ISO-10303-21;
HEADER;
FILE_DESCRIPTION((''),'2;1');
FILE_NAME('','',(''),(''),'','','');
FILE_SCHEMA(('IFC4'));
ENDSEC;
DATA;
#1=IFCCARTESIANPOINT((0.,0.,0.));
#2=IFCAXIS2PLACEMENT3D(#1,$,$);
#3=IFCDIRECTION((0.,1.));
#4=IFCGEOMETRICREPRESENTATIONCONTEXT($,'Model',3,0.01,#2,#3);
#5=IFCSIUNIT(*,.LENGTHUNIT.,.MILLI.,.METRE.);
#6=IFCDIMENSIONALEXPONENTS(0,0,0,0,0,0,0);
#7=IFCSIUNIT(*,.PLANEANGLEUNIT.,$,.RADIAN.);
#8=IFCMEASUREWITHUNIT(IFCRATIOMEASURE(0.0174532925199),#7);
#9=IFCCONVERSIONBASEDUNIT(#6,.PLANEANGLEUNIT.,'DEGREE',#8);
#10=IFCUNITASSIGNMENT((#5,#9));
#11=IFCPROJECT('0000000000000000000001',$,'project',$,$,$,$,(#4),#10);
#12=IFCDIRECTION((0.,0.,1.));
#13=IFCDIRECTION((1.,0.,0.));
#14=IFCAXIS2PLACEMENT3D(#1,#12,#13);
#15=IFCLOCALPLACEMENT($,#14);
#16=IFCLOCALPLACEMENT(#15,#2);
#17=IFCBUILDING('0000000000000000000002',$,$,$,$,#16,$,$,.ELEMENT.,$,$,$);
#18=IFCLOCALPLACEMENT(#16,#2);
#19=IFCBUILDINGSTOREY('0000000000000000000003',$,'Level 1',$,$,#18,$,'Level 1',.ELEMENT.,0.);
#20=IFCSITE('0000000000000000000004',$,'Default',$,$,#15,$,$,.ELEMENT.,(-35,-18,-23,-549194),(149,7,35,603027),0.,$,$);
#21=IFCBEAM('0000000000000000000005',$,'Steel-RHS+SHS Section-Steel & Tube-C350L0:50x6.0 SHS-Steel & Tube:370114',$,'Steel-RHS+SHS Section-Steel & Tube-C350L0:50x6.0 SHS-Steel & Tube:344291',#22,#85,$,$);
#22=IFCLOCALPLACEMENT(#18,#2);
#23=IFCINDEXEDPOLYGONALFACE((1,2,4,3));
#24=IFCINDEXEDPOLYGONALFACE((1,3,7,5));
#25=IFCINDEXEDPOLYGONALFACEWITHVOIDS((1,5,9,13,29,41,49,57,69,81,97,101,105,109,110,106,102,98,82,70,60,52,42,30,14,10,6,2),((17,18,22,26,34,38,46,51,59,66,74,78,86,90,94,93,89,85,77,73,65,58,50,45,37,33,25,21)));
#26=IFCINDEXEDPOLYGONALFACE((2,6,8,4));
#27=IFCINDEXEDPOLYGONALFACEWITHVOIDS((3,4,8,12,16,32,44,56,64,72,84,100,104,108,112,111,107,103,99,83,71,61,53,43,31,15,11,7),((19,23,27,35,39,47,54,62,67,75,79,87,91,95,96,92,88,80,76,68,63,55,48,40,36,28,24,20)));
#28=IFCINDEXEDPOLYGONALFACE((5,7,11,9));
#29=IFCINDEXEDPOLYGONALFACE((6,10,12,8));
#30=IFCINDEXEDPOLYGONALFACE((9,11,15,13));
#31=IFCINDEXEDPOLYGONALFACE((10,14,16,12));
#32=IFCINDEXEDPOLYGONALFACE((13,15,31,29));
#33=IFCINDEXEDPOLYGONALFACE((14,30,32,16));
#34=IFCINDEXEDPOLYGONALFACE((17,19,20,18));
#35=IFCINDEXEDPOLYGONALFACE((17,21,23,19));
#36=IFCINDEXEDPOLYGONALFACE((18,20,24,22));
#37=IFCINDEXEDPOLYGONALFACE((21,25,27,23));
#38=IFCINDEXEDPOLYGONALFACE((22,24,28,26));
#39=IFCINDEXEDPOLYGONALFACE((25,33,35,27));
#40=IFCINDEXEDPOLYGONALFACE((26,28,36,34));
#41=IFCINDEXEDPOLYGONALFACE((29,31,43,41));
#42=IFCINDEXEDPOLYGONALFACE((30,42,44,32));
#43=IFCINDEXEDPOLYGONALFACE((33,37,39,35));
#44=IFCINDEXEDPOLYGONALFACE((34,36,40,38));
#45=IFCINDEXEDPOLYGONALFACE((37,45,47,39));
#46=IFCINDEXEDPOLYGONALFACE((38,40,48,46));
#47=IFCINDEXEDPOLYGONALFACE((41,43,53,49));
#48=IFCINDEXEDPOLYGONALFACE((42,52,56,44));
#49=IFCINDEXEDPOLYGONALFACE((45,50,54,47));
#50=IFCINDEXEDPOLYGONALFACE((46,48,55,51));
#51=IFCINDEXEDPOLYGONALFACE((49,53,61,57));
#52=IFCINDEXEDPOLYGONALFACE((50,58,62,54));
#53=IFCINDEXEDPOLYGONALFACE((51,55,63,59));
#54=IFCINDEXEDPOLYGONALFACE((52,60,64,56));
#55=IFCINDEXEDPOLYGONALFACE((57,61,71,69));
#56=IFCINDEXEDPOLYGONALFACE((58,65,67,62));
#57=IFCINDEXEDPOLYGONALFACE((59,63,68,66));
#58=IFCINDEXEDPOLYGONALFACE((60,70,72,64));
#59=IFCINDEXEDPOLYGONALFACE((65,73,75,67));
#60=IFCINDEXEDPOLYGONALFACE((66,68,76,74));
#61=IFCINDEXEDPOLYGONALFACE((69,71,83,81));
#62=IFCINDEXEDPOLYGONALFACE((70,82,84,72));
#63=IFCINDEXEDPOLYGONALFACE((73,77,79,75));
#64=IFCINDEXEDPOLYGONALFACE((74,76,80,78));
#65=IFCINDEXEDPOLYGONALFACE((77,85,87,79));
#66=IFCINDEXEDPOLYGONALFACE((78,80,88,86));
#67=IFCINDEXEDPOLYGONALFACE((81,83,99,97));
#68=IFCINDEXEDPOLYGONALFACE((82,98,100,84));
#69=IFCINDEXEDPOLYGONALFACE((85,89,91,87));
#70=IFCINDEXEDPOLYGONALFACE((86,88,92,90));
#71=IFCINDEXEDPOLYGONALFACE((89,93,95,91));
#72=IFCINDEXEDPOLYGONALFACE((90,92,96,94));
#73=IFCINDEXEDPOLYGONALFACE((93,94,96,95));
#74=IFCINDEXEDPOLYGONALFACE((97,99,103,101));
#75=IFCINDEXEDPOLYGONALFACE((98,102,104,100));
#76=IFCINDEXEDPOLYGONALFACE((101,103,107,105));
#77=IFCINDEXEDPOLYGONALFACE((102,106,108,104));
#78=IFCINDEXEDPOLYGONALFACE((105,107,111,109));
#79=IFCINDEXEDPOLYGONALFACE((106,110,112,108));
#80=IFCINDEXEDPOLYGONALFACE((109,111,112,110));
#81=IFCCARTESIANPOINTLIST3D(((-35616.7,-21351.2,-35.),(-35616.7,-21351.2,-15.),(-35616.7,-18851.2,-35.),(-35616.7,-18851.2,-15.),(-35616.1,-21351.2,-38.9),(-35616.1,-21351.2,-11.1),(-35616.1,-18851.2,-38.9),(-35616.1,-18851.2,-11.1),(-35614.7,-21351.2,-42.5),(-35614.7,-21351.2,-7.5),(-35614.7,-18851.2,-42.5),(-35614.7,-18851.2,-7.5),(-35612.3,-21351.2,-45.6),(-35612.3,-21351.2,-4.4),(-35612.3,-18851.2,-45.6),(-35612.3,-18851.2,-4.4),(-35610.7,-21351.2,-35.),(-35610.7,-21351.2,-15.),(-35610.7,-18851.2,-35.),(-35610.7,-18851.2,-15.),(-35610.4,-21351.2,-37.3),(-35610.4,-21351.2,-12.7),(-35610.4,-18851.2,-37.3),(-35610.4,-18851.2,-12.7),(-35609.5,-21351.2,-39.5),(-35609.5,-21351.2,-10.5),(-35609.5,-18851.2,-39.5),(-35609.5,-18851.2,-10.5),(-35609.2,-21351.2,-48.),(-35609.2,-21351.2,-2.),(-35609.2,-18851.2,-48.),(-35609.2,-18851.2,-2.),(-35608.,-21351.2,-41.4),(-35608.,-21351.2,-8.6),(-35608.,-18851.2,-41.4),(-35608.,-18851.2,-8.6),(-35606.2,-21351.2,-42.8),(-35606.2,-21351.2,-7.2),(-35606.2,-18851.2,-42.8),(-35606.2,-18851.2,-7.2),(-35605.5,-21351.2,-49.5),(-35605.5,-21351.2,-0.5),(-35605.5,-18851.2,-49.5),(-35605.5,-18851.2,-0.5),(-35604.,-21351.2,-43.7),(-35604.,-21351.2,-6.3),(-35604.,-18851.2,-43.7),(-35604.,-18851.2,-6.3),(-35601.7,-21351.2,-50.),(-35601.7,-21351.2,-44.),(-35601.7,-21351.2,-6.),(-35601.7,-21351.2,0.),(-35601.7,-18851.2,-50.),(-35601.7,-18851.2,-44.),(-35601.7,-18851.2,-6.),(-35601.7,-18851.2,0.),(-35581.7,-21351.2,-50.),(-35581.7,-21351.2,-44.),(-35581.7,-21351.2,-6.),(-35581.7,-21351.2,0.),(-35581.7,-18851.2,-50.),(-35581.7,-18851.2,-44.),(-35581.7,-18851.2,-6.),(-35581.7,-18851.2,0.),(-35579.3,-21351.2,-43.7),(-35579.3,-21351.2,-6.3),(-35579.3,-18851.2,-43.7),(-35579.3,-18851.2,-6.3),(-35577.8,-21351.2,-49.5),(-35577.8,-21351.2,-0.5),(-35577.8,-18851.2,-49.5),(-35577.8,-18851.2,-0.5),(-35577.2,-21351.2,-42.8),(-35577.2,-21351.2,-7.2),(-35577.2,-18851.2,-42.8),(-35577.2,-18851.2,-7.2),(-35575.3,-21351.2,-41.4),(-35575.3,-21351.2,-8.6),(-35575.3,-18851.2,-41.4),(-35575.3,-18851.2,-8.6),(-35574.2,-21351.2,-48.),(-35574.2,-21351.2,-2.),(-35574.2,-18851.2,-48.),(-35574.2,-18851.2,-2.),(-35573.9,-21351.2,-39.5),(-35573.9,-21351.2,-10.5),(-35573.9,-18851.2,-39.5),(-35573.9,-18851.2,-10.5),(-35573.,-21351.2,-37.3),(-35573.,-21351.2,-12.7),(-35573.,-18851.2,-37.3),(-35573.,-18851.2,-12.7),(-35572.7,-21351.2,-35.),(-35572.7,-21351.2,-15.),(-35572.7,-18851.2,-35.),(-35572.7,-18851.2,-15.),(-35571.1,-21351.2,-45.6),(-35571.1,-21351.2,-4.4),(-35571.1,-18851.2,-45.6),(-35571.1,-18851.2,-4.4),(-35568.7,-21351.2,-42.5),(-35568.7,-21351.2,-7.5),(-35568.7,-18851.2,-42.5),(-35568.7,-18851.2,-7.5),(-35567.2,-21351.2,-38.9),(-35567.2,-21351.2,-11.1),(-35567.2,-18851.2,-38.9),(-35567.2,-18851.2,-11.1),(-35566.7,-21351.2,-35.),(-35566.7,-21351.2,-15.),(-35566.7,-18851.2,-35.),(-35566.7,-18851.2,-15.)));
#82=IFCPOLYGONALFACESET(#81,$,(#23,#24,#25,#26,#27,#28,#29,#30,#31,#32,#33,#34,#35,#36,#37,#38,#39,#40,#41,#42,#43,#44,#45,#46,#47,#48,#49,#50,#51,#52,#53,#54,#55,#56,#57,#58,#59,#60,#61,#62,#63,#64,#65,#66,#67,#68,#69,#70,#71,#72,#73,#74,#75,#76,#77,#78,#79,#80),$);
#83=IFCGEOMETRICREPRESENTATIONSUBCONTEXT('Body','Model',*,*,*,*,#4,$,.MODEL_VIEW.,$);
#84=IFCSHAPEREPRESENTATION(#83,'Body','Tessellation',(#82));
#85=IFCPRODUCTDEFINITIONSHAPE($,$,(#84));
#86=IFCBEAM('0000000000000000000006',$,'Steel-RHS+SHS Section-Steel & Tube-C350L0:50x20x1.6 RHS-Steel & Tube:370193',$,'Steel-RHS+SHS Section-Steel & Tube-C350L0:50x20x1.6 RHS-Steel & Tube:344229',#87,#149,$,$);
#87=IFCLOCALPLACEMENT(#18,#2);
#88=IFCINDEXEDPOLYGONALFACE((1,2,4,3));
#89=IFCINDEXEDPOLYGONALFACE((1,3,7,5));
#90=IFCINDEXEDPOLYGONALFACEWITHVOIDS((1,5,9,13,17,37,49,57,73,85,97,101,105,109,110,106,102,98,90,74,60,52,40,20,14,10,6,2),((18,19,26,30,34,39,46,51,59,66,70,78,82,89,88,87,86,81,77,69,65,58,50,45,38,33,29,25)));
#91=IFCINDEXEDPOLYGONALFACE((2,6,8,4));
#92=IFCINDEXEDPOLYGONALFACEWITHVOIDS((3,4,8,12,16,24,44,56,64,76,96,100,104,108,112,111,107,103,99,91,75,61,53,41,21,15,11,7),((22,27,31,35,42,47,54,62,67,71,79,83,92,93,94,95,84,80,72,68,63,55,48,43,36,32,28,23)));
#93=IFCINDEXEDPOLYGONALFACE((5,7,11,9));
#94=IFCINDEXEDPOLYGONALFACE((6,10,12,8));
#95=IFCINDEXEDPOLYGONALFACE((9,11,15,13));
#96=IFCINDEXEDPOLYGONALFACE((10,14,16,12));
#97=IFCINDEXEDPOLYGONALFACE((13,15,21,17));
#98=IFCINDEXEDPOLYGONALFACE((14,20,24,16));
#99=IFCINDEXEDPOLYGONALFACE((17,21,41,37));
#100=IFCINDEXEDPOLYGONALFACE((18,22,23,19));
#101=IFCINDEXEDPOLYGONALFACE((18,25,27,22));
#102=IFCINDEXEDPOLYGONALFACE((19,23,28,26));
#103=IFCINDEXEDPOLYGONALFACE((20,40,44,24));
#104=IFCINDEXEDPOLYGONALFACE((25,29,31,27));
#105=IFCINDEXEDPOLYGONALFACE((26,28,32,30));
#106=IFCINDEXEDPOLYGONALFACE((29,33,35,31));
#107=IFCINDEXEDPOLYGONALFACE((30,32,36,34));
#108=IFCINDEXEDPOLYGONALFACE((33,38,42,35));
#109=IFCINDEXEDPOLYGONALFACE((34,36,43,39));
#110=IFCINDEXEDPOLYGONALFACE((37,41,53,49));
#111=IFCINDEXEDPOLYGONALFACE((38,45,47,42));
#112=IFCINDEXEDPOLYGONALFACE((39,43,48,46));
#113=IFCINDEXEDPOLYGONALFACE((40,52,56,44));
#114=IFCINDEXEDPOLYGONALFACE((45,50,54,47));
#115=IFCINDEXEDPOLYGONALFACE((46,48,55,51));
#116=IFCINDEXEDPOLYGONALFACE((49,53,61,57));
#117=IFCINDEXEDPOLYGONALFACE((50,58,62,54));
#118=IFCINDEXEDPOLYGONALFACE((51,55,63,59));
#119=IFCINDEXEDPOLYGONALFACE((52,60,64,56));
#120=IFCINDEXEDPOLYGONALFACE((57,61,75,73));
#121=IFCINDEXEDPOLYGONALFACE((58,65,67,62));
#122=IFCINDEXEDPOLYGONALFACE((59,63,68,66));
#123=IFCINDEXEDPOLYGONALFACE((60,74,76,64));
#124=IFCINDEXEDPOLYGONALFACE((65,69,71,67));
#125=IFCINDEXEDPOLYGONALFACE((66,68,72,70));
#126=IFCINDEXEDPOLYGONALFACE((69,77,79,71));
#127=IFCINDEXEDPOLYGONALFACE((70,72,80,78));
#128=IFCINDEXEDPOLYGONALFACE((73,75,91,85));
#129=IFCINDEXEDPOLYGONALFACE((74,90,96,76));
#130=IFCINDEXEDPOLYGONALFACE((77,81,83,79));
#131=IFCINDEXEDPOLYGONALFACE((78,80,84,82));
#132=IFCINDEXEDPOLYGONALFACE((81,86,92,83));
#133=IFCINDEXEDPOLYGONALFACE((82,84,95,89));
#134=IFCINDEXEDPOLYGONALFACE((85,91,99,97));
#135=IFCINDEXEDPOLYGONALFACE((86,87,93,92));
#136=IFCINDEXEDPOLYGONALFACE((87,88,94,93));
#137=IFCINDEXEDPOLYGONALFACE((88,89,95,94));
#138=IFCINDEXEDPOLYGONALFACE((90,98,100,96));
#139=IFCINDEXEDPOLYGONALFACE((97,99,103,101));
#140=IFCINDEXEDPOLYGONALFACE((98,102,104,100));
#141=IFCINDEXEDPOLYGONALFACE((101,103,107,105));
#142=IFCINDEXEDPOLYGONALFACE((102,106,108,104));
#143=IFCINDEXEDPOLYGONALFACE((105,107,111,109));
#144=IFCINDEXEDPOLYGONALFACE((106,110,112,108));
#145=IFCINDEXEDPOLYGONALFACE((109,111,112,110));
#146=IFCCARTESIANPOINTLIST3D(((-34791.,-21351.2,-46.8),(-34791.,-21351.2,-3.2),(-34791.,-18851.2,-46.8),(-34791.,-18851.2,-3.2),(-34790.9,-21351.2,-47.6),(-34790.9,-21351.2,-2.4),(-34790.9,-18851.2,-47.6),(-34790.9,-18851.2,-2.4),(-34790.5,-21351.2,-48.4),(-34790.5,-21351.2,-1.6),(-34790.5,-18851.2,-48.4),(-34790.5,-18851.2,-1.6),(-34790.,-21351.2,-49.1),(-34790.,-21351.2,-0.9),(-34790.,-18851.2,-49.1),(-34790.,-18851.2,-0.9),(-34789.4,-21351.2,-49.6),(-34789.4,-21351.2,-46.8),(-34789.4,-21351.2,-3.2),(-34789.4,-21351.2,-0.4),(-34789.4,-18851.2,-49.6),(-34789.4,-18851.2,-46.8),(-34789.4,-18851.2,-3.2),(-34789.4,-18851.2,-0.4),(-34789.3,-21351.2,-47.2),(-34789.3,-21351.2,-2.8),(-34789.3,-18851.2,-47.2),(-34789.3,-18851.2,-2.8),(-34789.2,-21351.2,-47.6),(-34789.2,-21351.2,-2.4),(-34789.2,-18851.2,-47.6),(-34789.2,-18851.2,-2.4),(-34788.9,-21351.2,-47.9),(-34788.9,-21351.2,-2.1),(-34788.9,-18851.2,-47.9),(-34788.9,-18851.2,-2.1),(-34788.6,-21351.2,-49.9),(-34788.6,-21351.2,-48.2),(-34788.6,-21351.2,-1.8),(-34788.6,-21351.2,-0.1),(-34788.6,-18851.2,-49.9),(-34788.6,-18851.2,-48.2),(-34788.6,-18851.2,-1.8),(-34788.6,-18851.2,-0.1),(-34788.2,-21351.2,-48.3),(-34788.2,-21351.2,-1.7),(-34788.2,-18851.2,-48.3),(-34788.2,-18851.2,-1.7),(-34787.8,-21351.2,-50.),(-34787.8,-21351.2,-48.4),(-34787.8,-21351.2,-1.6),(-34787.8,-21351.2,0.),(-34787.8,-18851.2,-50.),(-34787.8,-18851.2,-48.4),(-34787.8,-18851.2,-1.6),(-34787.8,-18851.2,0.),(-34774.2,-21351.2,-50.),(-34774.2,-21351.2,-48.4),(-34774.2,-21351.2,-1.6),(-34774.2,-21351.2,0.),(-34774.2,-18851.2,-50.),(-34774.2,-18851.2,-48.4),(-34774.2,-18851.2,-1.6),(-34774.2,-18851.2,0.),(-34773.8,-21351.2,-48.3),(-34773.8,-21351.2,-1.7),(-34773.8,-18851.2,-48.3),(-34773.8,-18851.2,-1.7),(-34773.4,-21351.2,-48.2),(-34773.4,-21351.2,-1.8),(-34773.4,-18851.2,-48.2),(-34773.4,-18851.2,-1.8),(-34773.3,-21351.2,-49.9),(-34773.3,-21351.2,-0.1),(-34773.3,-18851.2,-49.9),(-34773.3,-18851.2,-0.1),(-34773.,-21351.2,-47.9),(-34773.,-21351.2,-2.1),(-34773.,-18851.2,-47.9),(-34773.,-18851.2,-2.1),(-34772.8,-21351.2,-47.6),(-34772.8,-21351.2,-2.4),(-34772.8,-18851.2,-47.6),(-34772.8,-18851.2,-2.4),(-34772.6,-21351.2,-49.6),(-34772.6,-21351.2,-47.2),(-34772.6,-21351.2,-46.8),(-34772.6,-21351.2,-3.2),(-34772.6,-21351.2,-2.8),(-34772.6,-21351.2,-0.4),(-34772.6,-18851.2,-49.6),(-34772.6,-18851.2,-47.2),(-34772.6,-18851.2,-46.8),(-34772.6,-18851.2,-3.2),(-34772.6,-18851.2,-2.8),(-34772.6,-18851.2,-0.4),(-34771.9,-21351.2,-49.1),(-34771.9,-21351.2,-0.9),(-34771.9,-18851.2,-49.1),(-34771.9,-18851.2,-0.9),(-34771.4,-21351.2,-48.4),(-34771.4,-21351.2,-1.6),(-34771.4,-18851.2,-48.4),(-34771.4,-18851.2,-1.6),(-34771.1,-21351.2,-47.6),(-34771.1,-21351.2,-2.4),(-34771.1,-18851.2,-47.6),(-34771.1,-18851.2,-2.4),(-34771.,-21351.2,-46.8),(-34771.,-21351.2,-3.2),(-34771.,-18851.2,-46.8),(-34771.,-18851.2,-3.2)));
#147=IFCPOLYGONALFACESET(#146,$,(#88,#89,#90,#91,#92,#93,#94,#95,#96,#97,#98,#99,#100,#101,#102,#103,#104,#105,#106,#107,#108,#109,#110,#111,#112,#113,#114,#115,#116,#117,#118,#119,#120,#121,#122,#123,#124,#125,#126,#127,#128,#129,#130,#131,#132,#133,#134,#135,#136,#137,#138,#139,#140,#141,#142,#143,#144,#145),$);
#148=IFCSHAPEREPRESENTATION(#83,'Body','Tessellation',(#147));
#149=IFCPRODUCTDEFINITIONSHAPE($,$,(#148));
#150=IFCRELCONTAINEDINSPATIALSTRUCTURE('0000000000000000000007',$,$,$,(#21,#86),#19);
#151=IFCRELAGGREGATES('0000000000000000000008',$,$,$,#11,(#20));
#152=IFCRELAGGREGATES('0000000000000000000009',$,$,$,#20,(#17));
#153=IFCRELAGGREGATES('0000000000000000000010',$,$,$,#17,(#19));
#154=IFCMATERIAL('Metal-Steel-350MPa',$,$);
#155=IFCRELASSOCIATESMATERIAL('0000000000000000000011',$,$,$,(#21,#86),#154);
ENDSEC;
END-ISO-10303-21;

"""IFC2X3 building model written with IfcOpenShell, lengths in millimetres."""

from ifc_helpers import new_model, entity, si_unit, converted_unit, direction, frame, frame_2d, origin, origin_with_axes, place, context, subcontext, project, spatial, polyline, circle_curve, parameter, trimmed, segment, composite_curve, outline, extrude, material, element, save


model = new_model("IFC2X3")

# Units and contexts
model_context = context("Model", 3, precision=0.01, world=origin(), true_north=direction((0.0, 1.0)))
body_context = subcontext(model_context, "Body", "Model", "MODEL_VIEW")
ifc_project = project(units=[si_unit("LENGTHUNIT", "METRE", prefix="MILLI"), converted_unit("PLANEANGLEUNIT", "DEGREE", entity("IfcRatioMeasure", 0.0174532925199), si_unit("PLANEANGLEUNIT", "RADIAN"), dimensions=[0, 0, 0, 0, 0, 0, 0])], contexts=[model_context])

# Site, building, storey
site_placement = place(None, origin_with_axes())
site = spatial("IfcSite", under=ifc_project, at=site_placement, Name="Default", CompositionType="ELEMENT", RefLatitude=(-35, -18, -23, -549194), RefLongitude=(149, 7, 35, 603027), RefElevation=0.0)
building_placement = place(site_placement, origin())
building = spatial("IfcBuilding", under=site, at=building_placement, CompositionType="ELEMENT")
storey_placement = place(building_placement, origin())
storey = spatial("IfcBuildingStorey", under=building, at=storey_placement, Name="Level 1", LongName="Level 1", CompositionType="ELEMENT", Elevation=0.0)

# Beams
ifc_material = material(Name="Metal-Steel-350MPa")
beam_1_placement = place(storey_placement, frame((-35591.7, -18851.2, 0.0), z_axis=(0.0, 0.0, 1.0), x_axis=(0.0, -1.0, 0.0)))
element("IfcBeam", 1, at=beam_1_placement, inside=storey, material=ifc_material, Name="Steel-RHS+SHS Section-Steel & Tube-C350L0:50x6.0 SHS-Steel & Tube:370114", ObjectType="Steel-RHS+SHS Section-Steel & Tube-C350L0:50x6.0 SHS-Steel & Tube:344291", context=body_context, shape_type="SweptSolid", body=[
    extrude(outline(composite_curve([segment(trimmed(circle_curve(frame_2d((-10.0, -10.0), x_axis=(1.0, 0.0)), 15.0), [parameter(180.0)], [parameter(270.0)], True, "PARAMETER"), True, "CONTINUOUS"), segment(polyline([(-10.0, -25.0), (10.0, -25.0)]), True, "CONTINUOUS"), segment(trimmed(circle_curve(frame_2d((10.0, -10.0), x_axis=(1.0, 0.0)), 15.0), [parameter(270.0)], [parameter(0.0)], True, "PARAMETER"), True, "CONTINUOUS"), segment(polyline([(25.0, -10.0), (25.0, 10.0)]), True, "CONTINUOUS"), segment(trimmed(circle_curve(frame_2d((10.0, 10.0), x_axis=(1.0, 0.0)), 15.0), [parameter(0.0)], [parameter(90.0)], True, "PARAMETER"), True, "CONTINUOUS"), segment(polyline([(10.0, 25.0), (-10.0, 25.0)]), True, "CONTINUOUS"), segment(trimmed(circle_curve(frame_2d((-10.0, 10.0), x_axis=(1.0, 0.0)), 15.0), [parameter(90.0)], [parameter(180.0)], True, "PARAMETER"), True, "CONTINUOUS"), segment(polyline([(-25.0, 10.0), (-25.0, -10.0)]), True, "CONTINUOUS")], self_intersect=False), holes=[composite_curve([segment(polyline([(10.0, -19.0), (-10.0, -19.0)]), True, "CONTINUOUS"), segment(trimmed(circle_curve(frame_2d((-10.0, -10.0), x_axis=(1.0, 0.0)), 9.0), [parameter(180.0)], [parameter(270.0)], True, "PARAMETER"), False, "CONTINUOUS"), segment(polyline([(-19.0, -10.0), (-19.0, 10.0)]), True, "CONTINUOUS"), segment(trimmed(circle_curve(frame_2d((-10.0, 10.0), x_axis=(1.0, 0.0)), 9.0), [parameter(90.0)], [parameter(180.0)], True, "PARAMETER"), False, "CONTINUOUS"), segment(polyline([(-10.0, 19.0), (10.0, 19.0)]), True, "CONTINUOUS"), segment(trimmed(circle_curve(frame_2d((10.0, 10.0), x_axis=(1.0, 0.0)), 9.0), [parameter(360.0)], [parameter(90.0)], True, "PARAMETER"), False, "CONTINUOUS"), segment(polyline([(19.0, 10.0), (19.0, -10.0)]), True, "CONTINUOUS"), segment(trimmed(circle_curve(frame_2d((10.0, -10.0), x_axis=(1.0, 0.0)), 9.0), [parameter(270.0)], [parameter(360.0)], True, "PARAMETER"), False, "CONTINUOUS")], self_intersect=False)]), frame((0.0, 0.0, -25.0), z_axis=(1.0, 0.0, 0.0), x_axis=(0.0, -1.0, 0.0)), (0.0, 0.0, 1.0), 2500.0),
])
beam_2_placement = place(storey_placement, frame((-34781.0, -18851.2, 0.0), z_axis=(0.0, 0.0, 1.0), x_axis=(0.0, -1.0, 0.0)))
element("IfcBeam", 2, at=beam_2_placement, inside=storey, material=ifc_material, Name="Steel-RHS+SHS Section-Steel & Tube-C350L0:50x20x1.6 RHS-Steel & Tube:370193", ObjectType="Steel-RHS+SHS Section-Steel & Tube-C350L0:50x20x1.6 RHS-Steel & Tube:344229", context=body_context, shape_type="SweptSolid", body=[
    extrude(outline(composite_curve([segment(trimmed(circle_curve(frame_2d((-6.8, -21.8), x_axis=(1.0, 0.0)), 3.2), [parameter(180.0)], [parameter(270.0)], True, "PARAMETER"), True, "CONTINUOUS"), segment(polyline([(-6.8, -25.0), (6.8, -25.0)]), True, "CONTINUOUS"), segment(trimmed(circle_curve(frame_2d((6.8, -21.8), x_axis=(1.0, 0.0)), 3.2), [parameter(270.0)], [parameter(0.0)], True, "PARAMETER"), True, "CONTINUOUS"), segment(polyline([(10.0, -21.8), (10.0, 21.8)]), True, "CONTINUOUS"), segment(trimmed(circle_curve(frame_2d((6.8, 21.8), x_axis=(1.0, 0.0)), 3.2), [parameter(0.0)], [parameter(90.0)], True, "PARAMETER"), True, "CONTINUOUS"), segment(polyline([(6.8, 25.0), (-6.8, 25.0)]), True, "CONTINUOUS"), segment(trimmed(circle_curve(frame_2d((-6.8, 21.8), x_axis=(1.0, 0.0)), 3.2), [parameter(90.0)], [parameter(180.0)], True, "PARAMETER"), True, "CONTINUOUS"), segment(polyline([(-10.0, 21.8), (-10.0, -21.8)]), True, "CONTINUOUS")], self_intersect=False), holes=[composite_curve([segment(polyline([(6.8, -23.4), (-6.8, -23.4)]), True, "CONTINUOUS"), segment(trimmed(circle_curve(frame_2d((-6.8, -21.8), x_axis=(1.0, 0.0)), 1.6), [parameter(180.0)], [parameter(270.0)], True, "PARAMETER"), False, "CONTINUOUS"), segment(polyline([(-8.4, -21.8), (-8.4, 21.8)]), True, "CONTINUOUS"), segment(trimmed(circle_curve(frame_2d((-6.8, 21.8), x_axis=(1.0, 0.0)), 1.6), [parameter(90.0)], [parameter(180.0)], True, "PARAMETER"), False, "CONTINUOUS"), segment(polyline([(-6.8, 23.4), (6.8, 23.4)]), True, "CONTINUOUS"), segment(trimmed(circle_curve(frame_2d((6.8, 21.8), x_axis=(1.0, 0.0)), 1.6), [parameter(360.0)], [parameter(90.0)], True, "PARAMETER"), False, "CONTINUOUS"), segment(polyline([(8.4, 21.8), (8.4, -21.8)]), True, "CONTINUOUS"), segment(trimmed(circle_curve(frame_2d((6.8, -21.8), x_axis=(1.0, 0.0)), 1.6), [parameter(270.0)], [parameter(0.0)], True, "PARAMETER"), False, "CONTINUOUS")], self_intersect=False)]), frame((0.0, 0.0, -25.0), z_axis=(1.0, 0.0, 0.0), x_axis=(0.0, -1.0, 0.0)), (0.0, 0.0, 1.0), 2500.0),
])

save(model, "model.ifc")
